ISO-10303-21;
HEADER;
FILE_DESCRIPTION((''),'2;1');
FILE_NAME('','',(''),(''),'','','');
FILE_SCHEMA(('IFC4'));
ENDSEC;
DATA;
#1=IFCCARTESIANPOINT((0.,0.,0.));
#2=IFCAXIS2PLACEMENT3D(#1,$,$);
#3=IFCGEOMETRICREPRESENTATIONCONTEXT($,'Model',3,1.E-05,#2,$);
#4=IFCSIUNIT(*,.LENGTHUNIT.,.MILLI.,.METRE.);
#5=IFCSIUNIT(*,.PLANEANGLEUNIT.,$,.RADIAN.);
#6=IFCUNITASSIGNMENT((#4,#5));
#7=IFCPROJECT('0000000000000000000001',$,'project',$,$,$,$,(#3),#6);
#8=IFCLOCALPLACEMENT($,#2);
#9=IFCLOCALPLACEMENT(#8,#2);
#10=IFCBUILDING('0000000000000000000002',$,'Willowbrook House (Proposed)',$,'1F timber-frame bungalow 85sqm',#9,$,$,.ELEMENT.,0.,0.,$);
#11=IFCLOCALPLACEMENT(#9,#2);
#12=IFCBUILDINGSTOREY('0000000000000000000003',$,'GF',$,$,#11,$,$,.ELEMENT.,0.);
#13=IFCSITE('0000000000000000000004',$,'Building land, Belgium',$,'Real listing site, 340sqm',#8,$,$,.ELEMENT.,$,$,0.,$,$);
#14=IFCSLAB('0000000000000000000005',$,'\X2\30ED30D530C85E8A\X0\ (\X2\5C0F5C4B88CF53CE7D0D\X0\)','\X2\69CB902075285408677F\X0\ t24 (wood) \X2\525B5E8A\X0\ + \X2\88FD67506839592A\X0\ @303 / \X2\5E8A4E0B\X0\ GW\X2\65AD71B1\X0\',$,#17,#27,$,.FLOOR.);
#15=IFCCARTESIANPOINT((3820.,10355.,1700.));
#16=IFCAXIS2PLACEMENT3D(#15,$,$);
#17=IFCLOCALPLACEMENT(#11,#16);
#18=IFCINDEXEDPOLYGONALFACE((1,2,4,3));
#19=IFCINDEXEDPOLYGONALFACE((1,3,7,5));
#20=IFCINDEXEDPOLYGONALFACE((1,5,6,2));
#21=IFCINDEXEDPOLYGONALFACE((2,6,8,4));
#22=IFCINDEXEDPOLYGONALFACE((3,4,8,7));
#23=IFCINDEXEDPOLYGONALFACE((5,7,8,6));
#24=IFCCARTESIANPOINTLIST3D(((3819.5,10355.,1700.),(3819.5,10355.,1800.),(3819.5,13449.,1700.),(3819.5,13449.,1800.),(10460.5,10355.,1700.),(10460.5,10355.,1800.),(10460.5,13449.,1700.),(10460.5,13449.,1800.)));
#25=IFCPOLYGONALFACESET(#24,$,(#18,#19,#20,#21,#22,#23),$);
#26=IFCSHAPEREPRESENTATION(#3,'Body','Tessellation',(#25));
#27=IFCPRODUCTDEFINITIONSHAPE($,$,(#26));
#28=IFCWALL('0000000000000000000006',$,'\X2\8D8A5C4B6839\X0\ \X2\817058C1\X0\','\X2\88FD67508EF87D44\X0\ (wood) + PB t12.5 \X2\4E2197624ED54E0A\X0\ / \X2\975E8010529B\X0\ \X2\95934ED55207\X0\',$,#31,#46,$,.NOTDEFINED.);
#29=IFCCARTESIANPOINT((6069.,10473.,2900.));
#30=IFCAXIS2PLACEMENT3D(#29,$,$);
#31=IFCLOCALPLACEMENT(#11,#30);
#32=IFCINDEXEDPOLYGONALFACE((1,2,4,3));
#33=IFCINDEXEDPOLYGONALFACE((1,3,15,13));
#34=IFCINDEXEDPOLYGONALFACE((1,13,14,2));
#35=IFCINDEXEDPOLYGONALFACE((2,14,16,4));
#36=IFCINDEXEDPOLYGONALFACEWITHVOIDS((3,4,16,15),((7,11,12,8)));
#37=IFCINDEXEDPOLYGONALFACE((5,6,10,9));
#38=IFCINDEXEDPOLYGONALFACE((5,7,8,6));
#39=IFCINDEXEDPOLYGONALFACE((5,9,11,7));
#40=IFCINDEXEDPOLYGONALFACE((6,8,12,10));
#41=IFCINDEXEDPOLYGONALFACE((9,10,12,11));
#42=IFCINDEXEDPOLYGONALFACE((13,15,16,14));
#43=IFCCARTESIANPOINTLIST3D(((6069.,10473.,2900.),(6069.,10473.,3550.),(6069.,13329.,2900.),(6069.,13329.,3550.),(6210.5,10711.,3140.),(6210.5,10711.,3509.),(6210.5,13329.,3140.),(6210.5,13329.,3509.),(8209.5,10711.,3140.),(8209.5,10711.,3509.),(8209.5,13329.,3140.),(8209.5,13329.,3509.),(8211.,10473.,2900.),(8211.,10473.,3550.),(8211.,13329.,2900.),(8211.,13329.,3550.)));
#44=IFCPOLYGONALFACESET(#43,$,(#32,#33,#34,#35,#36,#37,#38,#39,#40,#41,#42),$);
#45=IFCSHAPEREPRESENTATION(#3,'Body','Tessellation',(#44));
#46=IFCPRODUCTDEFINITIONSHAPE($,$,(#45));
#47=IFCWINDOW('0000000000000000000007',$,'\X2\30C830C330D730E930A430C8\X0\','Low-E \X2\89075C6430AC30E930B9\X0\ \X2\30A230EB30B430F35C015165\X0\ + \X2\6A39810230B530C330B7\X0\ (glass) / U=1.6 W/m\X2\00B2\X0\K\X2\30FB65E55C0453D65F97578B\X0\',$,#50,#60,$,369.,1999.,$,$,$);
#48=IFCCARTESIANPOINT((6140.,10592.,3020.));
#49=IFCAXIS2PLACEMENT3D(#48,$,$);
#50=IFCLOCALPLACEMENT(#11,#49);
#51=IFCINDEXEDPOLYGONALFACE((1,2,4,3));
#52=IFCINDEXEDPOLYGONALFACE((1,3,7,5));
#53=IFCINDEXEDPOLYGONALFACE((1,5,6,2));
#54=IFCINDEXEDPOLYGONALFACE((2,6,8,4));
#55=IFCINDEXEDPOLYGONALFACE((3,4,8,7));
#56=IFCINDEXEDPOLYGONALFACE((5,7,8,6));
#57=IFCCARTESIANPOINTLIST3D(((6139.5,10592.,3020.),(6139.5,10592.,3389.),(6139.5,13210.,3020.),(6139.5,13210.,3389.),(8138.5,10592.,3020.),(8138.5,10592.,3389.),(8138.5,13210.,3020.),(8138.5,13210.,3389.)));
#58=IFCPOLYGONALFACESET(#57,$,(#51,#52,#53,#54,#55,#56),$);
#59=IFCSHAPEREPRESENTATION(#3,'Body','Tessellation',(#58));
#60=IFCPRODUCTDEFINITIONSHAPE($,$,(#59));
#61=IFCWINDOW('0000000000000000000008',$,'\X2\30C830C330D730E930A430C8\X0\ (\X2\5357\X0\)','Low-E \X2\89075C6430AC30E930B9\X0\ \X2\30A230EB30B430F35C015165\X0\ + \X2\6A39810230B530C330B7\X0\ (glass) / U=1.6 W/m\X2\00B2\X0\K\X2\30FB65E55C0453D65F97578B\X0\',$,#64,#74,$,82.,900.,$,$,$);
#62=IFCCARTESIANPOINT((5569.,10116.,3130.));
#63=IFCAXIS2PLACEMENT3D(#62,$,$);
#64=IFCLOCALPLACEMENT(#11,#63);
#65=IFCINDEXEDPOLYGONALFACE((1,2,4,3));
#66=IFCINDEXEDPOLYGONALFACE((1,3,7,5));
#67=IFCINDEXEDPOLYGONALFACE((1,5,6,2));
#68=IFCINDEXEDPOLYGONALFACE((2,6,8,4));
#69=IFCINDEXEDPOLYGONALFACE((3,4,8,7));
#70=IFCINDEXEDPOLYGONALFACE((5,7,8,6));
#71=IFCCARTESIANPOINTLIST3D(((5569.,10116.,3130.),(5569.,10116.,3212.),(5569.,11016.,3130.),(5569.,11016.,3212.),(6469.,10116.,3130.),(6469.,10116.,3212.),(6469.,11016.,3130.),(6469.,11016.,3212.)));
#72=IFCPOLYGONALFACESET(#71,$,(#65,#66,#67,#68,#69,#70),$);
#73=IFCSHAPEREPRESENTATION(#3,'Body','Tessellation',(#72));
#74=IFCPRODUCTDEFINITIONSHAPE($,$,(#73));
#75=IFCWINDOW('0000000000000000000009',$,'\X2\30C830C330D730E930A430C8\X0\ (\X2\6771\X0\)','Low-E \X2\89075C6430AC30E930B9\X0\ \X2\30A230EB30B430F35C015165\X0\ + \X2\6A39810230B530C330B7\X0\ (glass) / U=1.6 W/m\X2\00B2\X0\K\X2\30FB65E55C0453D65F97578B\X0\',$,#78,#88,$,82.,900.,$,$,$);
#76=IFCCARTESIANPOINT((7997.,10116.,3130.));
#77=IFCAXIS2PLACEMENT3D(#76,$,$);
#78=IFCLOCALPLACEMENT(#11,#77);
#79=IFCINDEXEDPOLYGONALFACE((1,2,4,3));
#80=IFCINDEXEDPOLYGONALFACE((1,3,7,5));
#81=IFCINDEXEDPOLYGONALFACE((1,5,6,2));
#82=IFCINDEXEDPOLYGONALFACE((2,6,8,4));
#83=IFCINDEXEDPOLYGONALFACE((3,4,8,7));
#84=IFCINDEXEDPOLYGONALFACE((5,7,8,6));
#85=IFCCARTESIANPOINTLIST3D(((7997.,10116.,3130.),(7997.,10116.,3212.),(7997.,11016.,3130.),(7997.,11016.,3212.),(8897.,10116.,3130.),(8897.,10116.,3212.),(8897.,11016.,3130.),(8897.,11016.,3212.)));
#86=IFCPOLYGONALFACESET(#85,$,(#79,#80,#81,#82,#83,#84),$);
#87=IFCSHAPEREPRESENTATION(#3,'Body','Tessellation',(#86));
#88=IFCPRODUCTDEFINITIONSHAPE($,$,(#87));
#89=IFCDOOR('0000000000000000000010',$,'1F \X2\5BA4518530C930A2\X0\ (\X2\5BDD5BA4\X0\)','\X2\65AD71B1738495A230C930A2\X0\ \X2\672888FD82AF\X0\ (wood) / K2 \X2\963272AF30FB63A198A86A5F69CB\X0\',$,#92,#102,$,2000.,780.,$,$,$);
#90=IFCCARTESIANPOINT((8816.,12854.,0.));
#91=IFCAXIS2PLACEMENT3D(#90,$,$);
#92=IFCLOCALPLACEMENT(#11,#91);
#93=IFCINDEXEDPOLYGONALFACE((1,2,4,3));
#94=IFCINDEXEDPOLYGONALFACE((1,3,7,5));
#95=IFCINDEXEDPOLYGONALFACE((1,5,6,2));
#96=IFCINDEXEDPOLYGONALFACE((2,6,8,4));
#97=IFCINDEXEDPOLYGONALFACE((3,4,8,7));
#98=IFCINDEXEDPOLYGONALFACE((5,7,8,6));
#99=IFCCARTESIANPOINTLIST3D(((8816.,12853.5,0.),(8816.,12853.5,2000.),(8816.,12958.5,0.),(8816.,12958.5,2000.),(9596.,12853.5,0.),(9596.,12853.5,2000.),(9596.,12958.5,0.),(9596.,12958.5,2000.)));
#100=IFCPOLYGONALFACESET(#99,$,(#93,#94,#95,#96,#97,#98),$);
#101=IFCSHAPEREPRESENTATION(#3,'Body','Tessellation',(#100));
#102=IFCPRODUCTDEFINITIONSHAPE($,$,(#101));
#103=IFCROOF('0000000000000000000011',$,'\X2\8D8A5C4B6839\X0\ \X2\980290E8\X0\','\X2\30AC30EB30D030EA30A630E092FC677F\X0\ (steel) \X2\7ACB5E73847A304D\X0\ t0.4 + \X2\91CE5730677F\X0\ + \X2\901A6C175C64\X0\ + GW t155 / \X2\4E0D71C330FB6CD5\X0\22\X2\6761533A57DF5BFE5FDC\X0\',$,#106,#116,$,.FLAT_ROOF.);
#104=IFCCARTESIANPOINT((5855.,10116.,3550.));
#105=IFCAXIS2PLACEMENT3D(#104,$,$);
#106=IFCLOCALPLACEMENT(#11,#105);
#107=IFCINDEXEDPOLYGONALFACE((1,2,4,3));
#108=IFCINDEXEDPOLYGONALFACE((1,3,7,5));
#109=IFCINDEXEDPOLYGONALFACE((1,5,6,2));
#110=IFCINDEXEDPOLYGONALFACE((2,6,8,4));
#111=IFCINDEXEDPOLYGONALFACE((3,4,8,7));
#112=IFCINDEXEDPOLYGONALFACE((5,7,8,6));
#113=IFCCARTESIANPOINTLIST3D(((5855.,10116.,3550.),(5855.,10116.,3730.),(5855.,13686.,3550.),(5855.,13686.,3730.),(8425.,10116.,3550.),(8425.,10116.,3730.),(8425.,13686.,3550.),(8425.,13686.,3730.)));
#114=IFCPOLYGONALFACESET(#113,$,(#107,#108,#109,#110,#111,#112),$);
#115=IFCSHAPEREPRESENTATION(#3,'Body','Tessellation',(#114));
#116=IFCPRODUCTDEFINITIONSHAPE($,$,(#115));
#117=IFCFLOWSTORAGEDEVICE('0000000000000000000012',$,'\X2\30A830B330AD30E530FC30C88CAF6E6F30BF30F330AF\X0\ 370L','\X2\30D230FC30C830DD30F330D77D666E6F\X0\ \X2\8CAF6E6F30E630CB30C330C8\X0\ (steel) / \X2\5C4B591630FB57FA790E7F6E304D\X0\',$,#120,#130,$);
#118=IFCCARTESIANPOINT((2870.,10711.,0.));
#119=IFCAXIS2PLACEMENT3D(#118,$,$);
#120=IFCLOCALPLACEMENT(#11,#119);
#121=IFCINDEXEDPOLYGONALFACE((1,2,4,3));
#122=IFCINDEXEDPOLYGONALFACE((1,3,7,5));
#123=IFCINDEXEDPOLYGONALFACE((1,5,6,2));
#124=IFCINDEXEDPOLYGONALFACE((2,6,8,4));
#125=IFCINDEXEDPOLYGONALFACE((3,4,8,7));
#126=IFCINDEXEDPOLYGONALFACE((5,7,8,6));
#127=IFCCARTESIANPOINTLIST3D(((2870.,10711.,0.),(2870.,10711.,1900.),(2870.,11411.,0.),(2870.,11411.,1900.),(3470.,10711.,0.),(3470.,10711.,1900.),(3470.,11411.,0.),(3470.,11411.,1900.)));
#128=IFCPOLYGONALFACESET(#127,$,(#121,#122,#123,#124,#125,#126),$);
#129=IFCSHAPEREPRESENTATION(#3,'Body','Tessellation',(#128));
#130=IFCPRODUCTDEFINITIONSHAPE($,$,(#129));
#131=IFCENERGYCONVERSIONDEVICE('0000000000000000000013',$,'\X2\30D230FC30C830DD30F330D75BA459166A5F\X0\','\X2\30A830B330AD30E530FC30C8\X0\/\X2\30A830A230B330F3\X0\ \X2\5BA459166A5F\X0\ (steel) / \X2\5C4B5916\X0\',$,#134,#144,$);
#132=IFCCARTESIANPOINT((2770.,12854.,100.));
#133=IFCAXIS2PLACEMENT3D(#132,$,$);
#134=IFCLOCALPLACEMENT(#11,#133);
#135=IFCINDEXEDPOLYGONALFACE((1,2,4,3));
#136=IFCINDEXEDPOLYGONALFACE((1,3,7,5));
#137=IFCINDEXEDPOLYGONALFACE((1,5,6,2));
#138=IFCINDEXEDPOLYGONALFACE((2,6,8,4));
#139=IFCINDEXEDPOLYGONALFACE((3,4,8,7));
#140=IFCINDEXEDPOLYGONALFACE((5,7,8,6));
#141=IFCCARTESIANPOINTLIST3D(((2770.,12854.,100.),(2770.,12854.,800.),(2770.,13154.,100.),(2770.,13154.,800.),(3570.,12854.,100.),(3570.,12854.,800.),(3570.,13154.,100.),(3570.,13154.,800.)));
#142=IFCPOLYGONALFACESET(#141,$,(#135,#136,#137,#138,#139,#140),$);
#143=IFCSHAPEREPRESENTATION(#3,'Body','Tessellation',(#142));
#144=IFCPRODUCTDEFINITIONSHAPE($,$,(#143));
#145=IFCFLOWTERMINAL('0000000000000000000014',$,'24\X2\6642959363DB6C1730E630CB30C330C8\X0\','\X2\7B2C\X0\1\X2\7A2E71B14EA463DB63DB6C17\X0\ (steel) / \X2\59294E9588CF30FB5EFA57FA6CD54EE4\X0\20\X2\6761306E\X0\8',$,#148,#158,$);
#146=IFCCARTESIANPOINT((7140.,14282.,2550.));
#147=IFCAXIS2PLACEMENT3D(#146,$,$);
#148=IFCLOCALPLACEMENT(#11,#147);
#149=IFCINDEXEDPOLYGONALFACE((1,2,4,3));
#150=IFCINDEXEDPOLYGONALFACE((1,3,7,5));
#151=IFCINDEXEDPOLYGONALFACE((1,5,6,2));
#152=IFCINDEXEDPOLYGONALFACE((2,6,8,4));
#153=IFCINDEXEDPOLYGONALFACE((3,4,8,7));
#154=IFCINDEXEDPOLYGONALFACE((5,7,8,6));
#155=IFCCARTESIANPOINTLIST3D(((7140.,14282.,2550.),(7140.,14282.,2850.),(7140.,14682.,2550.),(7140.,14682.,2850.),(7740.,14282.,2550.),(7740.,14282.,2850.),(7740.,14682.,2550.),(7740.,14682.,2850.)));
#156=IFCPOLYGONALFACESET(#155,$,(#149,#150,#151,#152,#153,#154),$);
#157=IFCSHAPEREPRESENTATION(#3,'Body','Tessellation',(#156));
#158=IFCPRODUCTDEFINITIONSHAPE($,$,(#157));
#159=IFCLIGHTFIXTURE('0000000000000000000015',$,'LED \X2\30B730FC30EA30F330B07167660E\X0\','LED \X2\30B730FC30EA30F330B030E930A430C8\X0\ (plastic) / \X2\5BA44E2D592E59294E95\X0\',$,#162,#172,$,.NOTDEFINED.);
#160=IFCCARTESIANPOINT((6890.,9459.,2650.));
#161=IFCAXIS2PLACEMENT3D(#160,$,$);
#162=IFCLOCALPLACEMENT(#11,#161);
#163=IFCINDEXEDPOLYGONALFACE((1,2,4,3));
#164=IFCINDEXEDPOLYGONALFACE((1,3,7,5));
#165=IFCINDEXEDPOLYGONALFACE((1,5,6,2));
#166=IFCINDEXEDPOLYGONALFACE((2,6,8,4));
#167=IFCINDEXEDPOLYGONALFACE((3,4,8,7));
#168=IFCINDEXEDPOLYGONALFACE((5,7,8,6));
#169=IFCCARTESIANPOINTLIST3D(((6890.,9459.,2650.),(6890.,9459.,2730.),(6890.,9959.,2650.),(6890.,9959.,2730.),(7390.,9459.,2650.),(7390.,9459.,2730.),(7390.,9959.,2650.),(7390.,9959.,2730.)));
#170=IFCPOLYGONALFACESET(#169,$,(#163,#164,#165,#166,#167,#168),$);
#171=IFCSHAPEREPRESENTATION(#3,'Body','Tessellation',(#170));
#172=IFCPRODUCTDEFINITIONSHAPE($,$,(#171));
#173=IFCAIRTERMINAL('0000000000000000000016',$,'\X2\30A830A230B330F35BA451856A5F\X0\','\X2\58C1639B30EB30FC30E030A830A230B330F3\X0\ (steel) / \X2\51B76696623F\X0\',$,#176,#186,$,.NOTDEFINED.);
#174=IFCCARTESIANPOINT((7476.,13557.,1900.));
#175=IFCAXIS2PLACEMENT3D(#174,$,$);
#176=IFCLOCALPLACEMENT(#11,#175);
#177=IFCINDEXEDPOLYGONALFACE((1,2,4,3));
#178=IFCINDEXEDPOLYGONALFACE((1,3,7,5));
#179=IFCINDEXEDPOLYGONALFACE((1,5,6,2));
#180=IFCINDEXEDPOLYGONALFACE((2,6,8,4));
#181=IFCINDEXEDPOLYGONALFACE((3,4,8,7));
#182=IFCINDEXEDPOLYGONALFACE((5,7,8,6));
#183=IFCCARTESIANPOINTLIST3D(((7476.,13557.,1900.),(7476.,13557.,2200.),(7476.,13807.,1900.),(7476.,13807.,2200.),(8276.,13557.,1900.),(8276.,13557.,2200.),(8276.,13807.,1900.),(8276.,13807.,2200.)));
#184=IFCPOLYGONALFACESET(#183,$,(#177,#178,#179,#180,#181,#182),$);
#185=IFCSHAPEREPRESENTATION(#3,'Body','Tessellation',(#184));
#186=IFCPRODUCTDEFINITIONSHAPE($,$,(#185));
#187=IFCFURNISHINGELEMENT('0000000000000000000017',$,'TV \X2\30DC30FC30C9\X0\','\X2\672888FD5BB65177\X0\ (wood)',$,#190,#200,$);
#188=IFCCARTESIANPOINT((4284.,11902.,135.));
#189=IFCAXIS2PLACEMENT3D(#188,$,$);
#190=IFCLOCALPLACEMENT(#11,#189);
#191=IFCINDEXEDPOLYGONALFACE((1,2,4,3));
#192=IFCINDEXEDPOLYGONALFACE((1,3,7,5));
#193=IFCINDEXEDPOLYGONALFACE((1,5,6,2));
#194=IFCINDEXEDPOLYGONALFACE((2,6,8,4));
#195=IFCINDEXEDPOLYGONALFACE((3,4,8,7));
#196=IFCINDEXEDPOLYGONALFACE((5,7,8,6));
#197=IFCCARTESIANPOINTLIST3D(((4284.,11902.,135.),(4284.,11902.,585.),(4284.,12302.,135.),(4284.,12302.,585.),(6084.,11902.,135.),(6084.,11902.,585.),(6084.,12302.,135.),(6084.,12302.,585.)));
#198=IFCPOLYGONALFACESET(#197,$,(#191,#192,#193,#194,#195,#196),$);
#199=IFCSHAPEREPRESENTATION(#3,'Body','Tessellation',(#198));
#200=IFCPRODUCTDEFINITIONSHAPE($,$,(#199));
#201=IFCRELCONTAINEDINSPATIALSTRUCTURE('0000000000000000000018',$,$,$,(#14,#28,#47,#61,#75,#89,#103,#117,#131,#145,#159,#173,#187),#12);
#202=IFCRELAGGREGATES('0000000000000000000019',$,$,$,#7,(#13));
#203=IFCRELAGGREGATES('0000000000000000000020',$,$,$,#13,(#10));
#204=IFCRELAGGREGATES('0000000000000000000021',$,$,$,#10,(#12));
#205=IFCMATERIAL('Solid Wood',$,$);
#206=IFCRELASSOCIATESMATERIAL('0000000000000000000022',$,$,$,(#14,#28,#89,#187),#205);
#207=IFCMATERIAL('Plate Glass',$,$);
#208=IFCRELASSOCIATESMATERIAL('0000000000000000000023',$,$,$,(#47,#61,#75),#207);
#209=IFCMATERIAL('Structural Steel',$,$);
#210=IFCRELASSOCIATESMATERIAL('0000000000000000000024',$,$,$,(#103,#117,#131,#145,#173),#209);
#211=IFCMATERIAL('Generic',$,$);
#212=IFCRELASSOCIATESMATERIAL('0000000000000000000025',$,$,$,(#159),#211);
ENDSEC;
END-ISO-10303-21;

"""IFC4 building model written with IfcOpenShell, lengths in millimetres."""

from ifc_helpers import new_model, si_unit, frame, frame_2d, origin, place, context, project, spatial, rectangle, extrude, material, element, fill, save


model = new_model("IFC4")

# Units and contexts
model_context = context("Model", 3, precision=1e-05, world=origin())
ifc_project = project(units=[si_unit("LENGTHUNIT", "METRE", prefix="MILLI"), si_unit("PLANEANGLEUNIT", "RADIAN")], contexts=[model_context])

# Site, building, storey
site_placement = place(None, origin())
site = spatial("IfcSite", under=ifc_project, at=site_placement, Name="Building land, Belgium", ObjectType="Real listing site, 340sqm", CompositionType="ELEMENT", RefElevation=0.0)
building_placement = place(site_placement, origin())
building = spatial("IfcBuilding", under=site, at=building_placement, Name="Willowbrook House (Proposed)", ObjectType="1F timber-frame bungalow 85sqm", CompositionType="ELEMENT", ElevationOfRefHeight=0.0, ElevationOfTerrain=0.0)
storey_placement = place(building_placement, origin())
storey = spatial("IfcBuildingStorey", under=building, at=storey_placement, Name="GF", CompositionType="ELEMENT", Elevation=0.0)

# Shared definitions
ifc_material_1 = material(Name="Solid Wood")

# Slab
slab_placement = place(storey_placement, frame((3820.0, 10355.0, 1700.0)))
element("IfcSlab", 1, at=slab_placement, inside=storey, material=ifc_material_1, Name="ロフト床 (小屋裏収納)", Description="構造用合板 t24 (wood) 剛床 + 製材根太 @303 / 床下 GW断熱", PredefinedType="FLOOR", context=model_context, shape_type="SweptSolid", body=[
    extrude(rectangle(XDim=6641.0, YDim=3094.0, at=frame_2d((3320.0, 1547.0))), frame((3820.0, 10355.0, 1700.0)), (0.0, 0.0, 1.0), 100.0),
])

# Wall, openings, windows
wall_1_placement = place(storey_placement, frame((6069.0, 10473.0, 2900.0)))
wall_1 = element("IfcWall", 2, at=wall_1_placement, inside=storey, material=ifc_material_1, Name="越屋根 腰壁", Description="製材軸組 (wood) + PB t12.5 両面仕上 / 非耐力 間仕切", PredefinedType="NOTDEFINED", context=model_context, shape_type="SweptSolid", body=[
    extrude(rectangle(XDim=2142.0, YDim=2856.0, at=frame_2d((1071.0, 1428.0))), frame((6069.0, 10473.0, 2900.0)), (0.0, 0.0, 1.0), 650.0),
])
opening_1_placement = place(storey_placement, frame((6140.0, 10592.0, 3020.0)))
opening_1 = element("IfcOpeningElement", 3, at=opening_1_placement, cuts=wall_1, PredefinedType="NOTDEFINED", context=model_context, shape_type="SweptSolid", body=[
    extrude(rectangle(XDim=1999.0, YDim=2618.0, at=frame_2d((999.0, 1309.0))), frame((6140.0, 10592.0, 3020.0)), (0.0, 0.0, 1.0), 369.0),
])
opening_2_placement = place(storey_placement, frame((5569.0, 10116.0, 3130.0)))
opening_2 = element("IfcOpeningElement", 4, at=opening_2_placement, cuts=wall_1, PredefinedType="NOTDEFINED", context=model_context, shape_type="SweptSolid", body=[
    extrude(rectangle(XDim=900.0, YDim=900.0, at=frame_2d((450.0, 450.0))), frame((5569.0, 10116.0, 3130.0)), (0.0, 0.0, 1.0), 82.0),
])
opening_3_placement = place(storey_placement, frame((7997.0, 10116.0, 3130.0)))
opening_3 = element("IfcOpeningElement", 5, at=opening_3_placement, cuts=wall_1, PredefinedType="NOTDEFINED", context=model_context, shape_type="SweptSolid", body=[
    extrude(rectangle(XDim=900.0, YDim=900.0, at=frame_2d((450.0, 450.0))), frame((7997.0, 10116.0, 3130.0)), (0.0, 0.0, 1.0), 82.0),
])
ifc_material_2 = material(Name="Plate Glass")
window_1_placement = place(storey_placement, frame((6140.0, 10592.0, 3020.0)))
window_1 = element("IfcWindow", 6, at=window_1_placement, inside=storey, material=ifc_material_2, Name="トップライト", Description="Low-E 複層ガラス アルゴン封入 + 樹脂サッシ (glass) / U=1.6 W/m²K・日射取得型", OverallHeight=369.0, OverallWidth=1999.0, context=model_context, shape_type="SweptSolid", body=[
    extrude(rectangle(XDim=1999.0, YDim=2618.0, at=frame_2d((999.0, 1309.0))), frame((6140.0, 10592.0, 3020.0)), (0.0, 0.0, 1.0), 369.0),
])
fill(opening_1, window_1)
window_2_placement = place(storey_placement, frame((5569.0, 10116.0, 3130.0)))
window_2 = element("IfcWindow", 7, at=window_2_placement, inside=storey, material=ifc_material_2, Name="トップライト (南)", Description="Low-E 複層ガラス アルゴン封入 + 樹脂サッシ (glass) / U=1.6 W/m²K・日射取得型", OverallHeight=82.0, OverallWidth=900.0, context=model_context, shape_type="SweptSolid", body=[
    extrude(rectangle(XDim=900.0, YDim=900.0, at=frame_2d((450.0, 450.0))), frame((5569.0, 10116.0, 3130.0)), (0.0, 0.0, 1.0), 82.0),
])
fill(opening_2, window_2)
window_3_placement = place(storey_placement, frame((7997.0, 10116.0, 3130.0)))
window_3 = element("IfcWindow", 8, at=window_3_placement, inside=storey, material=ifc_material_2, Name="トップライト (東)", Description="Low-E 複層ガラス アルゴン封入 + 樹脂サッシ (glass) / U=1.6 W/m²K・日射取得型", OverallHeight=82.0, OverallWidth=900.0, context=model_context, shape_type="SweptSolid", body=[
    extrude(rectangle(XDim=900.0, YDim=900.0, at=frame_2d((450.0, 450.0))), frame((7997.0, 10116.0, 3130.0)), (0.0, 0.0, 1.0), 82.0),
])
fill(opening_3, window_3)

# Door
door_1_placement = place(storey_placement, frame((8816.0, 12854.0, 0.0)))
element("IfcDoor", 9, at=door_1_placement, inside=storey, material=ifc_material_1, Name="1F 室内ドア (寝室)", Description="断熱玄関ドア 木製芯 (wood) / K2 防犯・採風機構", OverallHeight=2000.0, OverallWidth=780.0, context=model_context, shape_type="SweptSolid", body=[
    extrude(rectangle(XDim=780.0, YDim=105.0, at=frame_2d((390.0, 52.0))), frame((8816.0, 12854.0, 0.0)), (0.0, 0.0, 1.0), 2000.0),
])

# Roof
ifc_material_3 = material(Name="Structural Steel")
roof_placement = place(storey_placement, frame((5855.0, 10116.0, 3550.0)))
element("IfcRoof", 10, at=roof_placement, inside=storey, material=ifc_material_3, Name="越屋根 頂部", Description="ガルバリウム鋼板 (steel) 立平葺き t0.4 + 野地板 + 通気層 + GW t155 / 不燃・法22条区域対応", PredefinedType="FLAT_ROOF", context=model_context, shape_type="SweptSolid", body=[
    extrude(rectangle(XDim=2570.0, YDim=3570.0, at=frame_2d((1285.0, 1785.0))), frame((5855.0, 10116.0, 3550.0)), (0.0, 0.0, 1.0), 180.0),
])

# Flow storage device
flow_storage_device_placement = place(storey_placement, frame((2870.0, 10711.0, 0.0)))
element("IfcFlowStorageDevice", 11, at=flow_storage_device_placement, inside=storey, material=ifc_material_3, Name="エコキュート貯湯タンク 370L", Description="ヒートポンプ給湯 貯湯ユニット (steel) / 屋外・基礎置き", context=model_context, shape_type="SweptSolid", body=[
    extrude(rectangle(XDim=600.0, YDim=700.0, at=frame_2d((300.0, 350.0))), frame((2870.0, 10711.0, 0.0)), (0.0, 0.0, 1.0), 1900.0),
])

# Energy conversion device
energy_conversion_device_placement = place(storey_placement, frame((2770.0, 12854.0, 100.0)))
element("IfcEnergyConversionDevice", 12, at=energy_conversion_device_placement, inside=storey, material=ifc_material_3, Name="ヒートポンプ室外機", Description="エコキュート/エアコン 室外機 (steel) / 屋外", context=model_context, shape_type="SweptSolid", body=[
    extrude(rectangle(XDim=800.0, YDim=300.0, at=frame_2d((400.0, 150.0))), frame((2770.0, 12854.0, 100.0)), (0.0, 0.0, 1.0), 700.0),
])

# Flow terminal
flow_terminal_placement = place(storey_placement, frame((7140.0, 14282.0, 2550.0)))
element("IfcFlowTerminal", 13, at=flow_terminal_placement, inside=storey, material=ifc_material_3, Name="24時間換気ユニット", Description="第1種熱交換換気 (steel) / 天井裏・建基法令20条の8", context=model_context, shape_type="SweptSolid", body=[
    extrude(rectangle(XDim=600.0, YDim=400.0, at=frame_2d((300.0, 200.0))), frame((7140.0, 14282.0, 2550.0)), (0.0, 0.0, 1.0), 300.0),
])

# Light fixture
ifc_material_4 = material(Name="Generic")
light_fixture_placement = place(storey_placement, frame((6890.0, 9459.0, 2650.0)))
element("IfcLightFixture", 14, at=light_fixture_placement, inside=storey, material=ifc_material_4, Name="LED シーリング照明", Description="LED シーリングライト (plastic) / 室中央天井", PredefinedType="NOTDEFINED", context=model_context, shape_type="SweptSolid", body=[
    extrude(rectangle(XDim=500.0, YDim=500.0, at=frame_2d((250.0, 250.0))), frame((6890.0, 9459.0, 2650.0)), (0.0, 0.0, 1.0), 80.0),
])

# Air terminal
air_terminal_placement = place(storey_placement, frame((7476.0, 13557.0, 1900.0)))
element("IfcAirTerminal", 15, at=air_terminal_placement, inside=storey, material=ifc_material_3, Name="エアコン室内機", Description="壁掛ルームエアコン (steel) / 冷暖房", PredefinedType="NOTDEFINED", context=model_context, shape_type="SweptSolid", body=[
    extrude(rectangle(XDim=800.0, YDim=250.0, at=frame_2d((400.0, 125.0))), frame((7476.0, 13557.0, 1900.0)), (0.0, 0.0, 1.0), 300.0),
])

# Furnishing element
furnishing_placement = place(storey_placement, frame((4284.0, 11902.0, 135.0)))
element("IfcFurnishingElement", 16, at=furnishing_placement, inside=storey, material=ifc_material_1, Name="TV ボード", Description="木製家具 (wood)", context=model_context, shape_type="SweptSolid", body=[
    extrude(rectangle(XDim=1800.0, YDim=400.0, at=frame_2d((900.0, 200.0))), frame((4284.0, 11902.0, 135.0)), (0.0, 0.0, 1.0), 450.0),
])

save(model, "model.ifc")
